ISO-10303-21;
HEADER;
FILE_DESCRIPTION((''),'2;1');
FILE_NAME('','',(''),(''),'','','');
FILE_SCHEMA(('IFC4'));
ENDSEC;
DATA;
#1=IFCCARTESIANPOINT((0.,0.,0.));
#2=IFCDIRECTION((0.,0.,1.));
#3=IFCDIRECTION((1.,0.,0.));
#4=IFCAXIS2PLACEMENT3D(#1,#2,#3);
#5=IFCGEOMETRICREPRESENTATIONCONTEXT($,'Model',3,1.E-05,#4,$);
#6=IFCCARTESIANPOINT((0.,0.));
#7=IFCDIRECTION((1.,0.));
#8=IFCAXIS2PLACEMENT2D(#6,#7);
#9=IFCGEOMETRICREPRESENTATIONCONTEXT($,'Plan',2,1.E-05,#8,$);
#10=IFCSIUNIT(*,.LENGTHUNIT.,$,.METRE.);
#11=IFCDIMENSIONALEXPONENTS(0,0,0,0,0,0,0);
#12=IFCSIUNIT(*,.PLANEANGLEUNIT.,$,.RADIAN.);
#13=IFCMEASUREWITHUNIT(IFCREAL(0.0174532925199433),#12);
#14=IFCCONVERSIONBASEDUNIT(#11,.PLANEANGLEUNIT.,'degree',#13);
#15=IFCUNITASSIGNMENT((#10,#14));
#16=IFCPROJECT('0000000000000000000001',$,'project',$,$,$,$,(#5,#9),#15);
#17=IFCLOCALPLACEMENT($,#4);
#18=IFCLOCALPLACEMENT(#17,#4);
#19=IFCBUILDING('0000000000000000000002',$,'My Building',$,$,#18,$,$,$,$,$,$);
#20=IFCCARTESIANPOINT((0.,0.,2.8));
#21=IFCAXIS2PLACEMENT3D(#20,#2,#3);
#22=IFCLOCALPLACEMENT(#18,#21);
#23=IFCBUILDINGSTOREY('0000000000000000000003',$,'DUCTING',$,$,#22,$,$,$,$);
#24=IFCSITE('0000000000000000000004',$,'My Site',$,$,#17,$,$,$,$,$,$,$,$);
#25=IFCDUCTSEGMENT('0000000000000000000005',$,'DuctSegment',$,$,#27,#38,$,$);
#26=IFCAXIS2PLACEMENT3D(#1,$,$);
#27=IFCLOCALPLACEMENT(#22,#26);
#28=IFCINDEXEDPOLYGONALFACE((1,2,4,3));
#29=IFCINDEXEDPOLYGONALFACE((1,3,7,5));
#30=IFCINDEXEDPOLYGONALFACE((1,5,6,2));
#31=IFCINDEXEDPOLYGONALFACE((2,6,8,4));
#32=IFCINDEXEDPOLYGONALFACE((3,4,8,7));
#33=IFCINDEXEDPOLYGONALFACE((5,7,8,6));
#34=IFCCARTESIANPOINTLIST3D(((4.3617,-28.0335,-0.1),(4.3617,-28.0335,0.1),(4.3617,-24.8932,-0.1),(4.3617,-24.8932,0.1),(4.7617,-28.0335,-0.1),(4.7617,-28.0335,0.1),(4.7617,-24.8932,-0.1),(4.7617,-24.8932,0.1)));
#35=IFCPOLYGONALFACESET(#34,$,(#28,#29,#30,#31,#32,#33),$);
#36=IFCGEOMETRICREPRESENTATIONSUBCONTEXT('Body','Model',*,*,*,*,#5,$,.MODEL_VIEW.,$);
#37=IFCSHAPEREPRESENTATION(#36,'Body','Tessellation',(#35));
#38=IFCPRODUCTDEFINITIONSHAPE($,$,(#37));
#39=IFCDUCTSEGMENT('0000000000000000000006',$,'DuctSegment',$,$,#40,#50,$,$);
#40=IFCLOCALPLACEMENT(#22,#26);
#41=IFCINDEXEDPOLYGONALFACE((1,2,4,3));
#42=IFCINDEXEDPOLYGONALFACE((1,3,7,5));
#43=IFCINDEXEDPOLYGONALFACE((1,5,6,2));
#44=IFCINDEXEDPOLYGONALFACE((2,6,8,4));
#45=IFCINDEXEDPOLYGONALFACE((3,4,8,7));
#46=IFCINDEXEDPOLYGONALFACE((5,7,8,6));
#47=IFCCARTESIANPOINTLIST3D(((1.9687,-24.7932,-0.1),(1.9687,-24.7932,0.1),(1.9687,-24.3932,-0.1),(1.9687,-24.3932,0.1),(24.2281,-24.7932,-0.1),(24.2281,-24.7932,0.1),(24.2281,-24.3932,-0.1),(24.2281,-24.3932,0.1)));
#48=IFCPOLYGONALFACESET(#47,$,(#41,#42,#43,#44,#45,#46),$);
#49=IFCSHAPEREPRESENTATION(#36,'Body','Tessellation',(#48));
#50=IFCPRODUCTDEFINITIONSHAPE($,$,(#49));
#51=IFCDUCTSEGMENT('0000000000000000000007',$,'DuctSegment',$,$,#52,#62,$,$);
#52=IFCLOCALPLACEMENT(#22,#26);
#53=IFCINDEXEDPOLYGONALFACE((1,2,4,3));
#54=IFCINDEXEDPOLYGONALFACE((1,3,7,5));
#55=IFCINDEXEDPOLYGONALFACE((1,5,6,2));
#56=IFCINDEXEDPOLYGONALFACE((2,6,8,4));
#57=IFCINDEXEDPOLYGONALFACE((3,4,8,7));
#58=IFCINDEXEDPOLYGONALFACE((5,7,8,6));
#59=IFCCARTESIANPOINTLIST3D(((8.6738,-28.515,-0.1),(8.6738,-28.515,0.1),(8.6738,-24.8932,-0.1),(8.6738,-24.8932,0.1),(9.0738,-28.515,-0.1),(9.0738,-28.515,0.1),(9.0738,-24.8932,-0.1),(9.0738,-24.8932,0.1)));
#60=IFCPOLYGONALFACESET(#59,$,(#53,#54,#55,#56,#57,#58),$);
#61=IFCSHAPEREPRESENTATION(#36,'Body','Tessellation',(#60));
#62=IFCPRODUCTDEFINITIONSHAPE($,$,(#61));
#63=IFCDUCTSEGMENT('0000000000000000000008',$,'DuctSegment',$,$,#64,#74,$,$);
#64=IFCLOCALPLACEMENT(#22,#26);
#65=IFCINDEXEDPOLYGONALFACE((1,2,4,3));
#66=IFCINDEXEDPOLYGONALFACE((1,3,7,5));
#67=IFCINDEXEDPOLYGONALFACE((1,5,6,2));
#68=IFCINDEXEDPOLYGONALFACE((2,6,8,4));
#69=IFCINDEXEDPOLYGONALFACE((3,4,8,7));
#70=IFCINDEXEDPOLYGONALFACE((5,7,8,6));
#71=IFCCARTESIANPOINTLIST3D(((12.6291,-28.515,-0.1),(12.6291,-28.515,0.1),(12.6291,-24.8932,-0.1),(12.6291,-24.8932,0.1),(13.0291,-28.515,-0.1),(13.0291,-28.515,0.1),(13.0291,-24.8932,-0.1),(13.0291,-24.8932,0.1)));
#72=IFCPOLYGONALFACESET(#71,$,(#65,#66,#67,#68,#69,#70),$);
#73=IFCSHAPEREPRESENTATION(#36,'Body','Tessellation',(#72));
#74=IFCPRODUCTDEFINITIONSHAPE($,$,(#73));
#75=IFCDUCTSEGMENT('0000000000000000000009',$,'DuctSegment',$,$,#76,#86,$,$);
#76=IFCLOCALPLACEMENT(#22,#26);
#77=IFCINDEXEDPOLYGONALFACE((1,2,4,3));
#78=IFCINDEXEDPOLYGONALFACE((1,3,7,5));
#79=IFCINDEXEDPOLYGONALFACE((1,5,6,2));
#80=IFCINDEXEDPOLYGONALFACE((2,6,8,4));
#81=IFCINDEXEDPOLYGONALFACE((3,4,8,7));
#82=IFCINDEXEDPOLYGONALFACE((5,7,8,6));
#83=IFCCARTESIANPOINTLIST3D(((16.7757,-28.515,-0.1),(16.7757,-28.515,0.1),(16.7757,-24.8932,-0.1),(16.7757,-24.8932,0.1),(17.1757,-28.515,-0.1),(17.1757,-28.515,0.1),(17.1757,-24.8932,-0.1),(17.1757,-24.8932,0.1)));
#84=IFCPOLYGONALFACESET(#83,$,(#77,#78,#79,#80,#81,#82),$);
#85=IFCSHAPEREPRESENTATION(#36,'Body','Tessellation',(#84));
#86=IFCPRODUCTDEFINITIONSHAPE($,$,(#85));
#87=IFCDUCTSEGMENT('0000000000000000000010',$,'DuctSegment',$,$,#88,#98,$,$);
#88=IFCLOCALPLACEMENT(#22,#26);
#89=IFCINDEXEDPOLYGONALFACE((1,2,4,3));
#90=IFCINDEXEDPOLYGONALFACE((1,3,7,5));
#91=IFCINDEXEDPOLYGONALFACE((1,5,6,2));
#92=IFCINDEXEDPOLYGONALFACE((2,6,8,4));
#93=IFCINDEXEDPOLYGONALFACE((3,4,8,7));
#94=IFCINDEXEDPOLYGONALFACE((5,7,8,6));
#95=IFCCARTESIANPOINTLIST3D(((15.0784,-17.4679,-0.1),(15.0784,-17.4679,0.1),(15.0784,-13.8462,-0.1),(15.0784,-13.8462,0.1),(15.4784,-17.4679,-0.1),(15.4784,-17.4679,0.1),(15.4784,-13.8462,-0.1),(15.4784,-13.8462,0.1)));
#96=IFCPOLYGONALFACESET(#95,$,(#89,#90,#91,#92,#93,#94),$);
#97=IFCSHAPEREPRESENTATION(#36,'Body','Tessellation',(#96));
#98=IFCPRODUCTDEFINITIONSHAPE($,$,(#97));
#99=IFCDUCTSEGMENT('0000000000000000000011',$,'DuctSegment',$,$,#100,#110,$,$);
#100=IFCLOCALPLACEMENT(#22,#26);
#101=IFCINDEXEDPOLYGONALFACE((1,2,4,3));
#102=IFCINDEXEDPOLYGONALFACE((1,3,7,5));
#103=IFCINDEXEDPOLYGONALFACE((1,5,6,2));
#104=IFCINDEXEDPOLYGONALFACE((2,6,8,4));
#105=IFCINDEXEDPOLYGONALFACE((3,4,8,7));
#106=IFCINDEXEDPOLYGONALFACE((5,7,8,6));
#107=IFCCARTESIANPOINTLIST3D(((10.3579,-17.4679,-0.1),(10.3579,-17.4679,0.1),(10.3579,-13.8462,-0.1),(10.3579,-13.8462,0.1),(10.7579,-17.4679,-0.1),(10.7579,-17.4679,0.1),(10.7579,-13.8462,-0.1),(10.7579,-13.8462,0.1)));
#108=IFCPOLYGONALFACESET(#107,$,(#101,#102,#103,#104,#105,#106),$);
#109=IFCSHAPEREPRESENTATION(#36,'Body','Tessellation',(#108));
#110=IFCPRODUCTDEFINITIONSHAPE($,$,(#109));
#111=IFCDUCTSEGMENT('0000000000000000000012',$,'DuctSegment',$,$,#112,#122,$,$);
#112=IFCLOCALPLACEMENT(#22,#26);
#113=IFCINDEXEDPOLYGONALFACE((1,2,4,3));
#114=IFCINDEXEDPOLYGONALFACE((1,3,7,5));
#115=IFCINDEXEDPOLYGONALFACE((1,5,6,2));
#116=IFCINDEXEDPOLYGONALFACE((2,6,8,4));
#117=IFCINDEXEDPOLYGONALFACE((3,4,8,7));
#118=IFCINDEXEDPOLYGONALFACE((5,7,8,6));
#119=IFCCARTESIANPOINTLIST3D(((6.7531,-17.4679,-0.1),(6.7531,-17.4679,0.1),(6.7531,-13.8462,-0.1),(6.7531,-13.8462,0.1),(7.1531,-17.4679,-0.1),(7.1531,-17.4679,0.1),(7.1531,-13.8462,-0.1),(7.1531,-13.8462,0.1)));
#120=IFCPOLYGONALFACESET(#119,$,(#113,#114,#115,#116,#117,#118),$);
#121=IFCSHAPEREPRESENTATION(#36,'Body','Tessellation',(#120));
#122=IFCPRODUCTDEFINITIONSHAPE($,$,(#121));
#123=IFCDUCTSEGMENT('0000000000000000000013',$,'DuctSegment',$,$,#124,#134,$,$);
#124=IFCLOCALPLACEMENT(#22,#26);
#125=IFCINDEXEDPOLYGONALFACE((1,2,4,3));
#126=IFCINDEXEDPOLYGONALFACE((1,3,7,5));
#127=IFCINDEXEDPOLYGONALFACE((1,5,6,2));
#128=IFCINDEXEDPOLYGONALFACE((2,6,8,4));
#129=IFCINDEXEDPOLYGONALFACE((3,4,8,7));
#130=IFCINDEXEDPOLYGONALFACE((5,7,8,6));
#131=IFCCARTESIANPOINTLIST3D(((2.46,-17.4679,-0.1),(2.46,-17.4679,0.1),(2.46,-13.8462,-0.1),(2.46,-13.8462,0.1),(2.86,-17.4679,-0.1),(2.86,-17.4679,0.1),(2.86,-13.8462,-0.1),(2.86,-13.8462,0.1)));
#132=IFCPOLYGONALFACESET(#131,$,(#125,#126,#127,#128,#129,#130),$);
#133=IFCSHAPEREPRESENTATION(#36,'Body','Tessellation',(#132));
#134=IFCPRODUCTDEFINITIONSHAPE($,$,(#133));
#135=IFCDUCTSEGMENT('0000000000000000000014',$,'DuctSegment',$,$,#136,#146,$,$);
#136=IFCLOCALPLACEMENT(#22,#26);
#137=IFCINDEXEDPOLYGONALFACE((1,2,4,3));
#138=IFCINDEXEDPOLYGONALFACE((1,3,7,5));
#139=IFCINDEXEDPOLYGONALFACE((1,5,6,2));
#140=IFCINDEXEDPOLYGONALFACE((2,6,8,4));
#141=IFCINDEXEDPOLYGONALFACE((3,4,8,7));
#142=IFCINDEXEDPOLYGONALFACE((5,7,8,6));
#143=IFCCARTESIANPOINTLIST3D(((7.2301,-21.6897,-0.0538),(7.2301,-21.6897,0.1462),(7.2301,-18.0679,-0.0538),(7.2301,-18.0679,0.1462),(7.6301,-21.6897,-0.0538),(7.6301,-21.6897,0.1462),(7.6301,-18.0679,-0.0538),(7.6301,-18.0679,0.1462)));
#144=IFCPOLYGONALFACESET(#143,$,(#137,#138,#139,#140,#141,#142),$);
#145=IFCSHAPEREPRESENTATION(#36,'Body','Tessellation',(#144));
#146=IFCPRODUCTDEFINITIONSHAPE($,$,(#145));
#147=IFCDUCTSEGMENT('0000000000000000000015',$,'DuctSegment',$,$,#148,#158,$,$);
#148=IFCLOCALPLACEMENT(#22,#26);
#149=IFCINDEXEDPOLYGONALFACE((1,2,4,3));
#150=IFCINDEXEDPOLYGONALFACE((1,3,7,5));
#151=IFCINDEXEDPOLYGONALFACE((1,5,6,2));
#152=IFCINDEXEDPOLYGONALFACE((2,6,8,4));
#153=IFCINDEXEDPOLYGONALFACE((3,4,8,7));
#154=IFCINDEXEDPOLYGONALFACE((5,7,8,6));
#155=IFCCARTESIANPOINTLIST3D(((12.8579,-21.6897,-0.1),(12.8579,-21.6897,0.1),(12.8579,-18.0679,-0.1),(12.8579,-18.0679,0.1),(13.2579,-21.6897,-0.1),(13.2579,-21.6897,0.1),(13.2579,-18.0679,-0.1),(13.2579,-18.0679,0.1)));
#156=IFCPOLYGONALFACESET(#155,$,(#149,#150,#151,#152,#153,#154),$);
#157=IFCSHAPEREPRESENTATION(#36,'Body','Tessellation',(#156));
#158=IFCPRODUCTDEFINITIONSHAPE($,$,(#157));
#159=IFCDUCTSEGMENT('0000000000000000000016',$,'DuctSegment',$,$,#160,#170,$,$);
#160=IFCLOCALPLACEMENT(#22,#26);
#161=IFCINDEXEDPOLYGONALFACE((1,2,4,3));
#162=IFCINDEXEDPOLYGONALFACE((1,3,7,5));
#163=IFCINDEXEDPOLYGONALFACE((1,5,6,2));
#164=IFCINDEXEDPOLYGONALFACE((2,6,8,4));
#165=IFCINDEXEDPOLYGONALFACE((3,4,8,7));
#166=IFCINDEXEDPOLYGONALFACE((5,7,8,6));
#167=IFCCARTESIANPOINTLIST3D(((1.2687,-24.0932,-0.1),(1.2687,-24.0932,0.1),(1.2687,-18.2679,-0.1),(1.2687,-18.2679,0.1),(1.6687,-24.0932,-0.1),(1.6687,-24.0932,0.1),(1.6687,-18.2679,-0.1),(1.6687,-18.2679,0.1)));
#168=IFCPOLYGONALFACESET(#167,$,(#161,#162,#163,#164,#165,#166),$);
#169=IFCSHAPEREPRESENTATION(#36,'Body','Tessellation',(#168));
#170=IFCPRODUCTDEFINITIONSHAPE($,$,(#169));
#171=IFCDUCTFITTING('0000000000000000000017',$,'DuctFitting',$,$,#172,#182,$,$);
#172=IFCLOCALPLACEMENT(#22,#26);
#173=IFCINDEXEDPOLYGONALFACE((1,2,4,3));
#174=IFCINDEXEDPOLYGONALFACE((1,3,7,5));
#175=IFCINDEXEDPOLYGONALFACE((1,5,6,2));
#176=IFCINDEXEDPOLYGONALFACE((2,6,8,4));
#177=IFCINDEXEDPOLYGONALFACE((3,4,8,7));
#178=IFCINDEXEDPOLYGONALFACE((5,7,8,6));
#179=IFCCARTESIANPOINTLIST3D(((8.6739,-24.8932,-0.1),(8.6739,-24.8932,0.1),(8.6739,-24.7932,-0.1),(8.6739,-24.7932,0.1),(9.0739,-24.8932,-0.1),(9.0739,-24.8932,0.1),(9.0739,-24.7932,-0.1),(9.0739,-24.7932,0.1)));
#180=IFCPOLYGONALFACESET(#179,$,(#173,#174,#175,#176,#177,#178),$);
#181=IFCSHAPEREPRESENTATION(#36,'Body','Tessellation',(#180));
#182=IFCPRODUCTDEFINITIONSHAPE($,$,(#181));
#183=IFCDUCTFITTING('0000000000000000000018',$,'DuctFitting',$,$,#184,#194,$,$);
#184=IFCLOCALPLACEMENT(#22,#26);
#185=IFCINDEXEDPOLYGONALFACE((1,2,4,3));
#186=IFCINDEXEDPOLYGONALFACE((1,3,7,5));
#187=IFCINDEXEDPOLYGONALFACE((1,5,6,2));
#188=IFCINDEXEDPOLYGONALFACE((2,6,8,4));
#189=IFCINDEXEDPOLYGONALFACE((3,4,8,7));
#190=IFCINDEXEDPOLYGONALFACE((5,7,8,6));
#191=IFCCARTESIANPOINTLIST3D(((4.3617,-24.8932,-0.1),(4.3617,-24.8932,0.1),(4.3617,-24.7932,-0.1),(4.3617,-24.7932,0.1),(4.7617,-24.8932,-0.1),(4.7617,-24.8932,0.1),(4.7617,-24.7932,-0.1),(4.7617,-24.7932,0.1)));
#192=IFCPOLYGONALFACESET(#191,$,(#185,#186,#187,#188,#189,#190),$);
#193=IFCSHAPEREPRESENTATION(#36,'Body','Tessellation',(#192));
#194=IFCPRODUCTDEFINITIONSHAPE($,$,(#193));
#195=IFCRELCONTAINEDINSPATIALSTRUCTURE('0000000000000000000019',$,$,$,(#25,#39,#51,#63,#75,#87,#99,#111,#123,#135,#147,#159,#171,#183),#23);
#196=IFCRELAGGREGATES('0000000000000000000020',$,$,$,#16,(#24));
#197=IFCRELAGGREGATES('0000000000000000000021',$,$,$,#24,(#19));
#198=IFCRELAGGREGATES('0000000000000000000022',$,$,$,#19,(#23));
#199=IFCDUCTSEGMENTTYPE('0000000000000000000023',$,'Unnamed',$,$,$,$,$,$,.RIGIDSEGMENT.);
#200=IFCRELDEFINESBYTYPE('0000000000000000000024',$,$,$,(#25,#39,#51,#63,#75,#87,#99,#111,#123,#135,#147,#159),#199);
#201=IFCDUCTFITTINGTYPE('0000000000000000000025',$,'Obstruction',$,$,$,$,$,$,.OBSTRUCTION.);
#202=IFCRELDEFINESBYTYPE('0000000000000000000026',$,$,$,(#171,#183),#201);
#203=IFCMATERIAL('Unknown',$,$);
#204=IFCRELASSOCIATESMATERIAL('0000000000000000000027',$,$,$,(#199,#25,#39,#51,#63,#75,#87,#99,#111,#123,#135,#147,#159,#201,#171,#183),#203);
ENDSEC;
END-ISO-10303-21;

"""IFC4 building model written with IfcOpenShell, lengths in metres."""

from ifc_helpers import new_model, entity, si_unit, converted_unit, frame, origin_with_axes, origin_2d_with_axis, place, context, subcontext, project, spatial, rectangle, extrude, material, material_profile, profile_set, profile_usage, type_object, element, save


model = new_model("IFC4")

# Units and contexts
model_context = context("Model", 3, precision=1e-05, world=origin_with_axes())
plan_context = context("Plan", 2, precision=1e-05, world=origin_2d_with_axis())
body_context = subcontext(model_context, "Body", "Model", "MODEL_VIEW")
ifc_project = project(units=[si_unit("LENGTHUNIT", "METRE"), converted_unit("PLANEANGLEUNIT", "degree", entity("IfcReal", 0.0174532925199433), si_unit("PLANEANGLEUNIT", "RADIAN"), dimensions=[0, 0, 0, 0, 0, 0, 0])], contexts=[model_context, plan_context])

# Site, building, storey
site_placement = place(None, origin_with_axes())
site = spatial("IfcSite", under=ifc_project, at=site_placement, Name="My Site")
building_placement = place(site_placement, origin_with_axes())
building = spatial("IfcBuilding", under=site, at=building_placement, Name="My Building")
storey_placement = place(building_placement, frame((0.0, 0.0, 2.8), z_axis=(0.0, 0.0, 1.0), x_axis=(1.0, 0.0, 0.0)))
storey = spatial("IfcBuildingStorey", under=building, at=storey_placement, Name="DUCTING")

# Duct segments
ifc_material = material(Name="Unknown")
ifc_material_profile_1 = material_profile(ifc_material, rectangle(XDim=0.4, YDim=0.2))
ifc_profile_set_1 = profile_set([ifc_material_profile_1])
ifc_profile_usage_1 = profile_usage(ifc_profile_set_1, cardinal=5)
duct_segment_type = type_object("IfcDuctSegmentType", Name="Unnamed", PredefinedType="RIGIDSEGMENT", material=ifc_profile_set_1)
duct_segment_1_placement = place(storey_placement, frame((4.5617, -28.0335, 0.0), z_axis=(0.0, 1.0, 0.0), x_axis=(-1.0, 0.0, 0.0)))
element("IfcDuctSegment", 1, at=duct_segment_1_placement, inside=storey, type_object=duct_segment_type, material=ifc_profile_usage_1, Name="DuctSegment", context=body_context, shape_type="SweptSolid", body=[
    extrude(rectangle(XDim=0.4, YDim=0.2), origin_with_axes(), (0.0, 0.0, 1.0), 3.1403),
])
ifc_profile_usage_2 = profile_usage(ifc_profile_set_1, cardinal=5)
duct_segment_2_placement = place(storey_placement, frame((1.9687, -24.5932, 0.0), z_axis=(1.0, 0.0, 0.0), x_axis=(0.0, -1.0, 0.0)))
element("IfcDuctSegment", 2, at=duct_segment_2_placement, inside=storey, type_object=duct_segment_type, material=ifc_profile_usage_2, Name="DuctSegment", context=body_context, shape_type="SweptSolid", body=[
    extrude(rectangle(XDim=0.4, YDim=0.2), origin_with_axes(), (0.0, 0.0, 1.0), 22.2594),
])
ifc_profile_usage_3 = profile_usage(ifc_profile_set_1, cardinal=5)
duct_segment_3_placement = place(storey_placement, frame((8.8738, -28.515, 0.0), z_axis=(0.0, 1.0, 0.0), x_axis=(-1.0, 0.0, 0.0)))
element("IfcDuctSegment", 3, at=duct_segment_3_placement, inside=storey, type_object=duct_segment_type, material=ifc_profile_usage_3, Name="DuctSegment", context=body_context, shape_type="SweptSolid", body=[
    extrude(rectangle(XDim=0.4, YDim=0.2), origin_with_axes(), (0.0, 0.0, 1.0), 3.6218),
])
ifc_profile_usage_4 = profile_usage(ifc_profile_set_1, cardinal=5)
duct_segment_4_placement = place(storey_placement, frame((12.8291, -28.515, 0.0), z_axis=(0.0, 1.0, 0.0), x_axis=(-1.0, 0.0, 0.0)))
element("IfcDuctSegment", 4, at=duct_segment_4_placement, inside=storey, type_object=duct_segment_type, material=ifc_profile_usage_4, Name="DuctSegment", context=body_context, shape_type="SweptSolid", body=[
    extrude(rectangle(XDim=0.4, YDim=0.2), origin_with_axes(), (0.0, 0.0, 1.0), 3.6218),
])
ifc_profile_usage_5 = profile_usage(ifc_profile_set_1, cardinal=5)
duct_segment_5_placement = place(storey_placement, frame((16.9757, -28.515, 0.0), z_axis=(0.0, 1.0, 0.0), x_axis=(-1.0, 0.0, 0.0)))
element("IfcDuctSegment", 5, at=duct_segment_5_placement, inside=storey, type_object=duct_segment_type, material=ifc_profile_usage_5, Name="DuctSegment", context=body_context, shape_type="SweptSolid", body=[
    extrude(rectangle(XDim=0.4, YDim=0.2), origin_with_axes(), (0.0, 0.0, 1.0), 3.6218),
])
ifc_profile_usage_6 = profile_usage(ifc_profile_set_1, cardinal=5)
duct_segment_6_placement = place(storey_placement, frame((15.2784, -13.8462, 0.0), z_axis=(0.0, -1.0, 0.0), x_axis=(1.0, 0.0, 0.0)))
element("IfcDuctSegment", 6, at=duct_segment_6_placement, inside=storey, type_object=duct_segment_type, material=ifc_profile_usage_6, Name="DuctSegment", context=body_context, shape_type="SweptSolid", body=[
    extrude(rectangle(XDim=0.4, YDim=0.2), origin_with_axes(), (0.0, 0.0, 1.0), 3.6218),
])
ifc_profile_usage_7 = profile_usage(ifc_profile_set_1, cardinal=5)
duct_segment_7_placement = place(storey_placement, frame((10.5579, -13.8462, 0.0), z_axis=(0.0, -1.0, 0.0), x_axis=(1.0, 0.0, 0.0)))
element("IfcDuctSegment", 7, at=duct_segment_7_placement, inside=storey, type_object=duct_segment_type, material=ifc_profile_usage_7, Name="DuctSegment", context=body_context, shape_type="SweptSolid", body=[
    extrude(rectangle(XDim=0.4, YDim=0.2), origin_with_axes(), (0.0, 0.0, 1.0), 3.6218),
])
ifc_profile_usage_8 = profile_usage(ifc_profile_set_1, cardinal=5)
duct_segment_8_placement = place(storey_placement, frame((6.9531, -13.8462, 0.0), z_axis=(0.0, -1.0, 0.0), x_axis=(1.0, 0.0, 0.0)))
element("IfcDuctSegment", 8, at=duct_segment_8_placement, inside=storey, type_object=duct_segment_type, material=ifc_profile_usage_8, Name="DuctSegment", context=body_context, shape_type="SweptSolid", body=[
    extrude(rectangle(XDim=0.4, YDim=0.2), origin_with_axes(), (0.0, 0.0, 1.0), 3.6218),
])
ifc_profile_usage_9 = profile_usage(ifc_profile_set_1, cardinal=5)
duct_segment_9_placement = place(storey_placement, frame((2.66, -13.8462, 0.0), z_axis=(0.0, -1.0, 0.0), x_axis=(1.0, 0.0, 0.0)))
element("IfcDuctSegment", 9, at=duct_segment_9_placement, inside=storey, type_object=duct_segment_type, material=ifc_profile_usage_9, Name="DuctSegment", context=body_context, shape_type="SweptSolid", body=[
    extrude(rectangle(XDim=0.4, YDim=0.2), origin_with_axes(), (0.0, 0.0, 1.0), 3.6218),
])
ifc_profile_usage_10 = profile_usage(ifc_profile_set_1, cardinal=5)
duct_segment_10_placement = place(storey_placement, frame((7.4301, -21.6897, 0.0462), z_axis=(0.0, 1.0, 0.0), x_axis=(-1.0, 0.0, 0.0)))
element("IfcDuctSegment", 10, at=duct_segment_10_placement, inside=storey, type_object=duct_segment_type, material=ifc_profile_usage_10, Name="DuctSegment", context=body_context, shape_type="SweptSolid", body=[
    extrude(rectangle(XDim=0.4, YDim=0.2), origin_with_axes(), (0.0, 0.0, 1.0), 3.6218),
])
ifc_profile_usage_11 = profile_usage(ifc_profile_set_1, cardinal=5)
duct_segment_11_placement = place(storey_placement, frame((13.0579, -21.6897, 0.0), z_axis=(0.0, 1.0, 0.0), x_axis=(-1.0, 0.0, 0.0)))
element("IfcDuctSegment", 11, at=duct_segment_11_placement, inside=storey, type_object=duct_segment_type, material=ifc_profile_usage_11, Name="DuctSegment", context=body_context, shape_type="SweptSolid", body=[
    extrude(rectangle(XDim=0.4, YDim=0.2), origin_with_axes(), (0.0, 0.0, 1.0), 3.6218),
])
ifc_profile_usage_12 = profile_usage(ifc_profile_set_1, cardinal=5)
duct_segment_12_placement = place(storey_placement, frame((1.4687, -18.2679, 0.0), z_axis=(0.0, -1.0, 0.0), x_axis=(1.0, 0.0, 0.0)))
element("IfcDuctSegment", 12, at=duct_segment_12_placement, inside=storey, type_object=duct_segment_type, material=ifc_profile_usage_12, Name="DuctSegment", context=body_context, shape_type="SweptSolid", body=[
    extrude(rectangle(XDim=0.4, YDim=0.2), origin_with_axes(), (0.0, 0.0, 1.0), 5.8253),
])

# Duct fittings
ifc_material_profile_2 = material_profile(ifc_material, rectangle(XDim=0.4, YDim=0.2))
ifc_profile_set_2 = profile_set([ifc_material_profile_2])
ifc_profile_usage_13 = profile_usage(ifc_profile_set_2, cardinal=5)
duct_fitting_type_1 = type_object("IfcDuctFittingType", Name="Obstruction", PredefinedType="OBSTRUCTION", material=ifc_profile_set_2)
duct_fitting_1_placement = place(storey_placement, frame((8.8739, -24.8932, 0.0), z_axis=(0.0, 1.0, 0.0), x_axis=(-1.0, 0.0, 0.0)))
element("IfcDuctFitting", 13, at=duct_fitting_1_placement, inside=storey, type_object=duct_fitting_type_1, material=ifc_profile_usage_13, Name="DuctFitting", context=body_context, shape_type="SweptSolid", body=[
    extrude(rectangle(XDim=0.4, YDim=0.2), origin_with_axes(), (0.0, 0.0, 1.0), 0.1),
])
ifc_profile_usage_14 = profile_usage(ifc_profile_set_2, cardinal=5)
duct_fitting_2_placement = place(storey_placement, frame((4.5617, -24.8932, 0.0), z_axis=(0.0, 1.0, 0.0), x_axis=(-1.0, 0.0, 0.0)))
element("IfcDuctFitting", 14, at=duct_fitting_2_placement, inside=storey, type_object=duct_fitting_type_1, material=ifc_profile_usage_14, Name="DuctFitting", context=body_context, shape_type="SweptSolid", body=[
    extrude(rectangle(XDim=0.4, YDim=0.2), origin_with_axes(), (0.0, 0.0, 1.0), 0.1),
])

save(model, "model.ifc")
